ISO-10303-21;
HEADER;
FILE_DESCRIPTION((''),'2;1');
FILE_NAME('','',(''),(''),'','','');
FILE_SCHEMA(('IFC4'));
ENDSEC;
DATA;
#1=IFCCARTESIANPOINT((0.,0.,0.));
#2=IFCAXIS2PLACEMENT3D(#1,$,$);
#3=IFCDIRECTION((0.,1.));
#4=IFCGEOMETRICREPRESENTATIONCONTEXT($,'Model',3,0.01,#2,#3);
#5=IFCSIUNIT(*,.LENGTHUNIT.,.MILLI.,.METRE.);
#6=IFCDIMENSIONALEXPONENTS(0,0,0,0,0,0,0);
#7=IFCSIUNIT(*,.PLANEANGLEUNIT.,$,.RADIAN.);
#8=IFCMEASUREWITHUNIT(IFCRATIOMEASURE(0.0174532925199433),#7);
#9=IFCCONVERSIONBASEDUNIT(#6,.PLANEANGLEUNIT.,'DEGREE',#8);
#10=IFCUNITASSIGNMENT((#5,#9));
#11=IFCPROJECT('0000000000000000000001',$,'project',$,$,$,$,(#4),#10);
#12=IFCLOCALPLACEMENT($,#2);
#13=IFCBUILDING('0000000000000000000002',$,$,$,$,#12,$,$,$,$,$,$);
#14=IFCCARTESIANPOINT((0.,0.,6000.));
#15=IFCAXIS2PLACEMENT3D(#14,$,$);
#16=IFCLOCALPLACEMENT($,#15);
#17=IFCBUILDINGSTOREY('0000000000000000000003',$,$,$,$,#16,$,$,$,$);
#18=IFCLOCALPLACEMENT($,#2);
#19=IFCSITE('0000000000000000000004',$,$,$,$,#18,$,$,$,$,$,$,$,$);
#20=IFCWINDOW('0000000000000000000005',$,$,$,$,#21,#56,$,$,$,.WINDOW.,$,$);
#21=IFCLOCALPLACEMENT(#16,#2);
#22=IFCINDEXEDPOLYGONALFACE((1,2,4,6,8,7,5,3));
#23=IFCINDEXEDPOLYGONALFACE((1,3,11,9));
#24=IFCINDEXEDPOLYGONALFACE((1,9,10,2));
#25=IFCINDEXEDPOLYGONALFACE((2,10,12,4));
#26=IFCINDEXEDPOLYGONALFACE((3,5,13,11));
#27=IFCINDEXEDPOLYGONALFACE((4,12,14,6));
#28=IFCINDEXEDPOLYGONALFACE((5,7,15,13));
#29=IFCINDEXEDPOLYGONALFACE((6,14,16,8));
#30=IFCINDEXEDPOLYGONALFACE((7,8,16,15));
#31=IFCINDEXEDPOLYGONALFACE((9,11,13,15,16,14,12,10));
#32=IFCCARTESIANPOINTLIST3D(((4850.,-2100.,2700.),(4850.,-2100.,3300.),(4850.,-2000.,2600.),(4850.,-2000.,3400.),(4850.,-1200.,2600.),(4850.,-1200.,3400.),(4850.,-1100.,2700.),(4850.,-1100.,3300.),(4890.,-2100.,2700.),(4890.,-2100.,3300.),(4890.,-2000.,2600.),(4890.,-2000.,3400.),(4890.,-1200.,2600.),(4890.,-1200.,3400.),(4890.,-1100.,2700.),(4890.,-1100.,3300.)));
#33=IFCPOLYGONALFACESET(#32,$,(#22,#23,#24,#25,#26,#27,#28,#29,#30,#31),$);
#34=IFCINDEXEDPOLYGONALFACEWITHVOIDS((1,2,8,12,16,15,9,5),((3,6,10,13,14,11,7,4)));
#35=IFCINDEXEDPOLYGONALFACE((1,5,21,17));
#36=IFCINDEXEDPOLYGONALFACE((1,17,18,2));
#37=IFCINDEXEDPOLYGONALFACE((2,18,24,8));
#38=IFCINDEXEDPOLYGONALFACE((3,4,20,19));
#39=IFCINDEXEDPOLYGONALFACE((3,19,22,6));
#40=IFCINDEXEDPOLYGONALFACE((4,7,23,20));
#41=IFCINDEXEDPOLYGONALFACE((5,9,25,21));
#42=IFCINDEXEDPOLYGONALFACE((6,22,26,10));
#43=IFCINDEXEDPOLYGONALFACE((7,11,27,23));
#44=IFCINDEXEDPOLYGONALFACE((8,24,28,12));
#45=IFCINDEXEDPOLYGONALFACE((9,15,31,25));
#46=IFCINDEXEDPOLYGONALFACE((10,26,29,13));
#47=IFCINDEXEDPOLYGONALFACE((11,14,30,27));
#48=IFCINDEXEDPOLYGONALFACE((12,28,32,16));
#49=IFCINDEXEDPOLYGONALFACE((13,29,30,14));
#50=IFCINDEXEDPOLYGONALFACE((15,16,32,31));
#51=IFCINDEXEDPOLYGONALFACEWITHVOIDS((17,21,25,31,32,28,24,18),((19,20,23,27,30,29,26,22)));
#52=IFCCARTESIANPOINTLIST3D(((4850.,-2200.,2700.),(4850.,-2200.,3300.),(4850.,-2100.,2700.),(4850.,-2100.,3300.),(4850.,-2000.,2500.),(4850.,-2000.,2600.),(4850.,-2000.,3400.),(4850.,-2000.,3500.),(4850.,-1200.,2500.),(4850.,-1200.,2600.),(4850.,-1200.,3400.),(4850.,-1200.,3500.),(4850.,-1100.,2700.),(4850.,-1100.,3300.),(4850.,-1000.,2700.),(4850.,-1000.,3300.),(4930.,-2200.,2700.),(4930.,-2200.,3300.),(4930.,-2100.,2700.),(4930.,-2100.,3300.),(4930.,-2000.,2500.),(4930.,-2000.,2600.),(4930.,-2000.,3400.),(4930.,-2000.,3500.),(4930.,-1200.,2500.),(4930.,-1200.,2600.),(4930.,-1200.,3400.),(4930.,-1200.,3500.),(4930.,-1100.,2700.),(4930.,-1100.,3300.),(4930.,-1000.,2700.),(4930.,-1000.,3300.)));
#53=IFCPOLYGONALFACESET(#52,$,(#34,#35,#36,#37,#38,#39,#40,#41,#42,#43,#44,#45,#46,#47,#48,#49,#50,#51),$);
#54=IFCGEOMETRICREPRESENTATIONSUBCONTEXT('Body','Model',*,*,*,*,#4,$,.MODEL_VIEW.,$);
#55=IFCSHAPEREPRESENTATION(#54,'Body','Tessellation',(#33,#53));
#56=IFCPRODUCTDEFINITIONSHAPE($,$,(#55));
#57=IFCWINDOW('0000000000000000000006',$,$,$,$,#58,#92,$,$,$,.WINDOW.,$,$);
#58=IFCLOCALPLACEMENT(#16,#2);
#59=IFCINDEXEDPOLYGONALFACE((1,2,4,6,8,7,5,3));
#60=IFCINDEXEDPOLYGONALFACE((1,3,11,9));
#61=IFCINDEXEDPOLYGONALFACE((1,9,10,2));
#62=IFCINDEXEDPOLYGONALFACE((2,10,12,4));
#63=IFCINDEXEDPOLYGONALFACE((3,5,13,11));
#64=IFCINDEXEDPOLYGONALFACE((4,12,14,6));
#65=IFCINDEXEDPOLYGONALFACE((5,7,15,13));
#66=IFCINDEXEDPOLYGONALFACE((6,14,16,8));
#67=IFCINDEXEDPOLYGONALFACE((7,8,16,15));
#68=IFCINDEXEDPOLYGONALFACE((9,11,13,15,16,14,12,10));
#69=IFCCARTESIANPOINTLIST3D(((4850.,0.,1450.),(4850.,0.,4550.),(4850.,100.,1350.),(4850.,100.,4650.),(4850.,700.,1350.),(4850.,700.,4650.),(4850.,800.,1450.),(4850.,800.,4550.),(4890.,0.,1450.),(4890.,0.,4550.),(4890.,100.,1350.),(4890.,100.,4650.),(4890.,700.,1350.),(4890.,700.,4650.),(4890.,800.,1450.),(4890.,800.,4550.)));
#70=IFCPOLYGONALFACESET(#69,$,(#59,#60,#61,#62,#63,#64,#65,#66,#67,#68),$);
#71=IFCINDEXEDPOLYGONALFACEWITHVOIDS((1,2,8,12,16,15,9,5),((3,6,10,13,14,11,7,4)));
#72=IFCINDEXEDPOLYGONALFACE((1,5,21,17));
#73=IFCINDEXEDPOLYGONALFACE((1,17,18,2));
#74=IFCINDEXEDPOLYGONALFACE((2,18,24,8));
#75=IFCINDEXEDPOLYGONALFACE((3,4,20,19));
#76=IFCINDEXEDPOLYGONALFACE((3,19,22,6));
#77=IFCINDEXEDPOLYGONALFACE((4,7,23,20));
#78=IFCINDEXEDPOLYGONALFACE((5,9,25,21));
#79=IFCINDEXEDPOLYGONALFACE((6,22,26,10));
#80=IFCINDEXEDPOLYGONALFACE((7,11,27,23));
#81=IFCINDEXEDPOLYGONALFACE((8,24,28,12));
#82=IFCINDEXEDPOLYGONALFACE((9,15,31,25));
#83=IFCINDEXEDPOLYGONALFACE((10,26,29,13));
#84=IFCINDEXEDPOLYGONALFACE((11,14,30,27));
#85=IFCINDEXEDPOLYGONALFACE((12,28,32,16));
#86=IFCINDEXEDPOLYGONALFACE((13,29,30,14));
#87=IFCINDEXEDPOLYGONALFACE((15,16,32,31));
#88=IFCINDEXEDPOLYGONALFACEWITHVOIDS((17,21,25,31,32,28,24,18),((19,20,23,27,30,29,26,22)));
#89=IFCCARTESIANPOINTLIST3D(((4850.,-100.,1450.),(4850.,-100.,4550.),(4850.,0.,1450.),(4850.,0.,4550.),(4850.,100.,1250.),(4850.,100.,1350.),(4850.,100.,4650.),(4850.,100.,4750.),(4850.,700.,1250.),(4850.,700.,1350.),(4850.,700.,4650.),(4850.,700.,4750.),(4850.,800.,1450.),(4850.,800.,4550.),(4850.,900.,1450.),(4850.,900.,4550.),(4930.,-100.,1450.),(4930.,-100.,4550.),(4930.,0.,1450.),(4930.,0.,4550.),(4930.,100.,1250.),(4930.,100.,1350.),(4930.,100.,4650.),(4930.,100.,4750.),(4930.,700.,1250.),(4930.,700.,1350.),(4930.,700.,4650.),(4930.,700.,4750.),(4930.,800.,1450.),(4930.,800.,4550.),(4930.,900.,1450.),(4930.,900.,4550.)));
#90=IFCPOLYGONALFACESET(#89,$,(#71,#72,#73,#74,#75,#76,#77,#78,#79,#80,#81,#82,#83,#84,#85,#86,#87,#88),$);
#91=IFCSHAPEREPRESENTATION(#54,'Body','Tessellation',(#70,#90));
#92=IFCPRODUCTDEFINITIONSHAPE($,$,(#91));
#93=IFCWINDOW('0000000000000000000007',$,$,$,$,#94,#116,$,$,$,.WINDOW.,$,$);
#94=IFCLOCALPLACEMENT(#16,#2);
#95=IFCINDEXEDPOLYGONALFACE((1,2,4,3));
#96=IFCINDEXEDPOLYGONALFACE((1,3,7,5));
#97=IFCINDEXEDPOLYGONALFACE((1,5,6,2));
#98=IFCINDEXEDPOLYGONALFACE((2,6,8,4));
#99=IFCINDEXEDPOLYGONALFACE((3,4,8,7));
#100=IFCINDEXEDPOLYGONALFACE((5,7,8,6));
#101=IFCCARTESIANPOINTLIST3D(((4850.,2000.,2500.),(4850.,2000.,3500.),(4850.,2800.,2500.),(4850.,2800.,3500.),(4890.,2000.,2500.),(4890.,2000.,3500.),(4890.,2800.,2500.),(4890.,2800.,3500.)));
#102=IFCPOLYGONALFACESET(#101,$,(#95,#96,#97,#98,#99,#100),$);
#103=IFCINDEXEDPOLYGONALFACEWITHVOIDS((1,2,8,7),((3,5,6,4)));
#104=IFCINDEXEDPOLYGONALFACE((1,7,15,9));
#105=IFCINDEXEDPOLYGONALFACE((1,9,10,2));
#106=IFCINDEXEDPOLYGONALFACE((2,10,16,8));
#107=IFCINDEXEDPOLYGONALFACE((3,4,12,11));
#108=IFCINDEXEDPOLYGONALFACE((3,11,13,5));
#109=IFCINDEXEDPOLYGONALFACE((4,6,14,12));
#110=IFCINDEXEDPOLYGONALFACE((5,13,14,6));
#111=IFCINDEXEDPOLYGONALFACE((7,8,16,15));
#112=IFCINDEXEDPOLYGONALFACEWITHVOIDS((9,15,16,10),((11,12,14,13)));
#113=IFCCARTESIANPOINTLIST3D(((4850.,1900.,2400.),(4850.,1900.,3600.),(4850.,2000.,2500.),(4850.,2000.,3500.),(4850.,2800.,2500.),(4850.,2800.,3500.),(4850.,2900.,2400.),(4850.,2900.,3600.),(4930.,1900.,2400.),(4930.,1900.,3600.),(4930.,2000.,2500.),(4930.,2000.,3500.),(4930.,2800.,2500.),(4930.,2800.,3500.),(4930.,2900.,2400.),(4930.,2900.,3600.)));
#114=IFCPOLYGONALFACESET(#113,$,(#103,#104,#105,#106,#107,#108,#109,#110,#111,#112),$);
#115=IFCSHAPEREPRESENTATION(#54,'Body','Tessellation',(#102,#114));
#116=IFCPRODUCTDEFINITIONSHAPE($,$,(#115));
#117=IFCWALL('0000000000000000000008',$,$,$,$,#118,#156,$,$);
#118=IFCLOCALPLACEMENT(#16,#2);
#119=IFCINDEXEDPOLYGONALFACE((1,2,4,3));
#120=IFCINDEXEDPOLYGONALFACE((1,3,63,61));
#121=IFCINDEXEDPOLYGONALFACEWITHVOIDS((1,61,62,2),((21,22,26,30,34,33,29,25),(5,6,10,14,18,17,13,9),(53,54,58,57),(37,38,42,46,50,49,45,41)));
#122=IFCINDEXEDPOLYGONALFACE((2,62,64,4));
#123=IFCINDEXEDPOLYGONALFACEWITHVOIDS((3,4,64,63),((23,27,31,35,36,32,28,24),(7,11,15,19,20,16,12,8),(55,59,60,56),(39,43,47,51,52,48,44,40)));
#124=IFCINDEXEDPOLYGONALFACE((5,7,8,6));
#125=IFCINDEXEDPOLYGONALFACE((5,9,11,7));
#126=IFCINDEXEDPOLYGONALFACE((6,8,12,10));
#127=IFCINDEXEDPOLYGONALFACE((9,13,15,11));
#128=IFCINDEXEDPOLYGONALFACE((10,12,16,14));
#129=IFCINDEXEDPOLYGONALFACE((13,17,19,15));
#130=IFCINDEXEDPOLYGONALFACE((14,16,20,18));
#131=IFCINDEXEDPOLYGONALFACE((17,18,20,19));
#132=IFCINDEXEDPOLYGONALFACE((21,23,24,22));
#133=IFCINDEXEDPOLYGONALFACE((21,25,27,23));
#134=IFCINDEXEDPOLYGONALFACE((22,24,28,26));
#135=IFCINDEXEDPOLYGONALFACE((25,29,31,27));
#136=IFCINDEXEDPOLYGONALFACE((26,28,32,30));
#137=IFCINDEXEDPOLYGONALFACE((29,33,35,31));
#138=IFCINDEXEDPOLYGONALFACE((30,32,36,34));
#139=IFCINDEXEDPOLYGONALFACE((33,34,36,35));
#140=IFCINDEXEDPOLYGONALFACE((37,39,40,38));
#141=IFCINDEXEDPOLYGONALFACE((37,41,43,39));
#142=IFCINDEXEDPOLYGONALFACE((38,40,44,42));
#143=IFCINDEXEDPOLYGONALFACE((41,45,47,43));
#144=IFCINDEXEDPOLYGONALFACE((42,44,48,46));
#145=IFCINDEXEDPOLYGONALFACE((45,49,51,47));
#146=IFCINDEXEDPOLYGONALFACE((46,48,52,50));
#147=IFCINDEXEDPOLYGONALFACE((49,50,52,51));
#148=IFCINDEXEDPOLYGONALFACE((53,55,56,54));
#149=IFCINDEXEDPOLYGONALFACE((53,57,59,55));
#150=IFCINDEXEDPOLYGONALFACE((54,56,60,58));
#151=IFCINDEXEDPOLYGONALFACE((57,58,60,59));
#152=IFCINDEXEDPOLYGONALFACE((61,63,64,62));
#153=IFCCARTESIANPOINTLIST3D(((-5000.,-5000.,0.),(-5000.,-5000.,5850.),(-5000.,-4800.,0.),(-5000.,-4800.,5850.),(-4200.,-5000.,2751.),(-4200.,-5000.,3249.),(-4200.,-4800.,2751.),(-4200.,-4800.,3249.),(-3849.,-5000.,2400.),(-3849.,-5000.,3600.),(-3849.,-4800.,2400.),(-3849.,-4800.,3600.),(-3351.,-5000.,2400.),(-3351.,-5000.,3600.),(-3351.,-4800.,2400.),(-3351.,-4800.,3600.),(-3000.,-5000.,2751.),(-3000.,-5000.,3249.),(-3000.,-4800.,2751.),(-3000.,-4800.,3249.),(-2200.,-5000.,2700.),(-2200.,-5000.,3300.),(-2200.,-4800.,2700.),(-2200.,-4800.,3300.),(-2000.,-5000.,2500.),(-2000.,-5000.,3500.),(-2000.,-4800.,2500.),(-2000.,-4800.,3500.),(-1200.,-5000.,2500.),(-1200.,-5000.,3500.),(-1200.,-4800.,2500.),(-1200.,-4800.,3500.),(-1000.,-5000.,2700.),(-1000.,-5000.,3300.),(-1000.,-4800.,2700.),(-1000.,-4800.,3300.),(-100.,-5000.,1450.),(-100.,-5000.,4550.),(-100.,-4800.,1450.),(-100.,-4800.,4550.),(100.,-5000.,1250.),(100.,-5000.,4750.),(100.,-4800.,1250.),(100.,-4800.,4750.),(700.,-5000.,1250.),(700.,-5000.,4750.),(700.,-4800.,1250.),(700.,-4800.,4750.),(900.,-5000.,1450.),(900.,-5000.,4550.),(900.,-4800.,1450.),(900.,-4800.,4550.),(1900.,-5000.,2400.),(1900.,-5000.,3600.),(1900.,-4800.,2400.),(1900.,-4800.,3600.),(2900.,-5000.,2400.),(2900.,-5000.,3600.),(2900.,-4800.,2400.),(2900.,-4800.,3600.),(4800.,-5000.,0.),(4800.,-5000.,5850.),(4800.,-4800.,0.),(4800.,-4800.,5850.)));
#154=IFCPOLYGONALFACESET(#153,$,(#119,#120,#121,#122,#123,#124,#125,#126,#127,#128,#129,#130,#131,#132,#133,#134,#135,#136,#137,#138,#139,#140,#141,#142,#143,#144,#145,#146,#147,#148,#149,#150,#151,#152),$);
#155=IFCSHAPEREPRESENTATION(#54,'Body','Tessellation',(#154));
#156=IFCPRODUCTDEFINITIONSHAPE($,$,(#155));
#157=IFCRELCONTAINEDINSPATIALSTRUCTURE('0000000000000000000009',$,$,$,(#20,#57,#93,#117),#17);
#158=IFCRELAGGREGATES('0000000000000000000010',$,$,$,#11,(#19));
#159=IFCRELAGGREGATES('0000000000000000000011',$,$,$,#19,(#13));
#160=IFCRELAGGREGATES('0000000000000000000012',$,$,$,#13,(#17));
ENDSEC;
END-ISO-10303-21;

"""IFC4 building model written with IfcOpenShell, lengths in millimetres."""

from ifc_helpers import new_model, entity, si_unit, converted_unit, direction, frame, origin, origin_2d, place, context, subcontext, project, spatial, polyline, rectangle, outline, extrude, element, save


model = new_model("IFC4")

# Units and contexts
model_context = context("Model", 3, precision=0.01, world=origin(), true_north=direction((0.0, 1.0)))
body_context = subcontext(model_context, "Body", "Model", "MODEL_VIEW")
ifc_project = project(units=[si_unit("LENGTHUNIT", "METRE", prefix="MILLI"), converted_unit("PLANEANGLEUNIT", "DEGREE", entity("IfcRatioMeasure", 0.0174532925199433), si_unit("PLANEANGLEUNIT", "RADIAN"), dimensions=[0, 0, 0, 0, 0, 0, 0])], contexts=[model_context])

# Site, building, storey
site_placement = place(None, origin())
site = spatial("IfcSite", under=ifc_project, at=site_placement)
building_placement = place(None, origin())
building = spatial("IfcBuilding", under=site, at=building_placement)
storey_placement = place(None, frame((0.0, 0.0, 6000.0)))
storey = spatial("IfcBuildingStorey", under=building, at=storey_placement)

# Shared definitions
cartesian_point_1 = entity("IfcCartesianPoint", [-500.0, -300.0])
shared_polyline_1 = entity("IfcPolyline", [cartesian_point_1, entity("IfcCartesianPoint", [-500.0, 300.0]), entity("IfcCartesianPoint", [-400.0, 400.0]), entity("IfcCartesianPoint", [400.0, 400.0]), entity("IfcCartesianPoint", [500.0, 300.0]), entity("IfcCartesianPoint", [500.0, -300.0]), entity("IfcCartesianPoint", [400.0, -400.0]), entity("IfcCartesianPoint", [-400.0, -400.0]), cartesian_point_1])
cartesian_point_2 = entity("IfcCartesianPoint", [-400.0, -1550.0])
shared_polyline_2 = entity("IfcPolyline", [cartesian_point_2, entity("IfcCartesianPoint", [-400.0, 1550.0]), entity("IfcCartesianPoint", [-300.0, 1650.0]), entity("IfcCartesianPoint", [300.0, 1650.0]), entity("IfcCartesianPoint", [400.0, 1550.0]), entity("IfcCartesianPoint", [400.0, -1550.0]), entity("IfcCartesianPoint", [300.0, -1650.0]), entity("IfcCartesianPoint", [-300.0, -1650.0]), cartesian_point_2])
cartesian_point_3 = entity("IfcCartesianPoint", [-400.0, -500.0])
shared_polyline_3 = entity("IfcPolyline", [cartesian_point_3, entity("IfcCartesianPoint", [-400.0, 500.0]), entity("IfcCartesianPoint", [-400.0, 500.0]), entity("IfcCartesianPoint", [400.0, 500.0]), entity("IfcCartesianPoint", [400.0, 500.0]), entity("IfcCartesianPoint", [400.0, -500.0]), entity("IfcCartesianPoint", [400.0, -500.0]), entity("IfcCartesianPoint", [-400.0, -500.0]), cartesian_point_3])

# Shared definitions
wall_1_placement = place(storey_placement, frame((4900.0, -100.0, 0.0), z_axis=(0.0, 0.0, 1.0), x_axis=(0.0, 1.0, 0.0)))
window_1_placement = place(wall_1_placement, frame((-1500.0, 50.0, 3000.0)))
window_2_placement = place(wall_1_placement, frame((500.0, 50.0, 3000.0)))
window_3_placement = place(wall_1_placement, frame((2500.0, 50.0, 3000.0)))

# Windows
cartesian_point_4 = entity("IfcCartesianPoint", [-600.0, -300.0])
element("IfcWindow", 1, at=window_1_placement, inside=storey, PredefinedType="WINDOW", context=body_context, shape_type="SweptSolid", body=[
    entity("IfcExtrudedAreaSolid", entity("IfcArbitraryClosedProfileDef", "AREA", None, shared_polyline_1), entity("IfcAxis2Placement3D", entity("IfcCartesianPoint", [0.0, 0.0, 0.0]), entity("IfcDirection", [0.0, -1.0, 0.0]), entity("IfcDirection", [1.0, 0.0, 0.0])), entity("IfcDirection", [0.0, 0.0, 1.0]), 40.0),
    entity("IfcExtrudedAreaSolid", entity("IfcArbitraryProfileDefWithVoids", "AREA", None, entity("IfcPolyline", [cartesian_point_4, entity("IfcCartesianPoint", [-600.0, 300.0]), entity("IfcCartesianPoint", [-400.0, 500.0]), entity("IfcCartesianPoint", [400.0, 500.0]), entity("IfcCartesianPoint", [600.0, 300.0]), entity("IfcCartesianPoint", [600.0, -300.0]), entity("IfcCartesianPoint", [400.0, -500.0]), entity("IfcCartesianPoint", [-400.0, -500.0]), cartesian_point_4]), [shared_polyline_1]), entity("IfcAxis2Placement3D", entity("IfcCartesianPoint", [0.0, 0.0, 0.0]), entity("IfcDirection", [0.0, -1.0, 0.0]), entity("IfcDirection", [1.0, 0.0, 0.0])), entity("IfcDirection", [0.0, 0.0, 1.0]), 80.0),
])
cartesian_point_5 = entity("IfcCartesianPoint", [-500.0, -1550.0])
element("IfcWindow", 2, at=window_2_placement, inside=storey, PredefinedType="WINDOW", context=body_context, shape_type="SweptSolid", body=[
    entity("IfcExtrudedAreaSolid", entity("IfcArbitraryClosedProfileDef", "AREA", None, shared_polyline_2), entity("IfcAxis2Placement3D", entity("IfcCartesianPoint", [0.0, 0.0, 0.0]), entity("IfcDirection", [0.0, -1.0, 0.0]), entity("IfcDirection", [1.0, 0.0, 0.0])), entity("IfcDirection", [0.0, 0.0, 1.0]), 40.0),
    entity("IfcExtrudedAreaSolid", entity("IfcArbitraryProfileDefWithVoids", "AREA", None, entity("IfcPolyline", [cartesian_point_5, entity("IfcCartesianPoint", [-500.0, 1550.0]), entity("IfcCartesianPoint", [-300.0, 1750.0]), entity("IfcCartesianPoint", [300.0, 1750.0]), entity("IfcCartesianPoint", [500.0, 1550.0]), entity("IfcCartesianPoint", [500.0, -1550.0]), entity("IfcCartesianPoint", [300.0, -1750.0]), entity("IfcCartesianPoint", [-300.0, -1750.0]), cartesian_point_5]), [shared_polyline_2]), entity("IfcAxis2Placement3D", entity("IfcCartesianPoint", [0.0, 0.0, 0.0]), entity("IfcDirection", [0.0, -1.0, 0.0]), entity("IfcDirection", [1.0, 0.0, 0.0])), entity("IfcDirection", [0.0, 0.0, 1.0]), 80.0),
])
cartesian_point_6 = entity("IfcCartesianPoint", [-500.0, -600.0])
element("IfcWindow", 3, at=window_3_placement, inside=storey, PredefinedType="WINDOW", context=body_context, shape_type="SweptSolid", body=[
    entity("IfcExtrudedAreaSolid", entity("IfcArbitraryClosedProfileDef", "AREA", None, shared_polyline_3), entity("IfcAxis2Placement3D", entity("IfcCartesianPoint", [0.0, 0.0, 0.0]), entity("IfcDirection", [0.0, -1.0, 0.0]), entity("IfcDirection", [1.0, 0.0, 0.0])), entity("IfcDirection", [0.0, 0.0, 1.0]), 40.0),
    entity("IfcExtrudedAreaSolid", entity("IfcArbitraryProfileDefWithVoids", "AREA", None, entity("IfcPolyline", [cartesian_point_6, entity("IfcCartesianPoint", [-500.0, 600.0]), entity("IfcCartesianPoint", [-500.0, 600.0]), entity("IfcCartesianPoint", [500.0, 600.0]), entity("IfcCartesianPoint", [500.0, 600.0]), entity("IfcCartesianPoint", [500.0, -600.0]), entity("IfcCartesianPoint", [500.0, -600.0]), entity("IfcCartesianPoint", [-500.0, -600.0]), cartesian_point_6]), [shared_polyline_3]), entity("IfcAxis2Placement3D", entity("IfcCartesianPoint", [0.0, 0.0, 0.0]), entity("IfcDirection", [0.0, -1.0, 0.0]), entity("IfcDirection", [1.0, 0.0, 0.0])), entity("IfcDirection", [0.0, 0.0, 1.0]), 80.0),
])

# Wall, openings
wall_2_placement = place(storey_placement, frame((-100.0, -4900.0, 0.0), z_axis=(0.0, 0.0, 1.0), x_axis=(1.0, 0.0, 0.0)))
wall_2 = element("IfcWall", 4, at=wall_2_placement, inside=storey, context=body_context, shape_type="SweptSolid", body=[
    extrude(rectangle(XDim=9800.0, YDim=200.0, at=origin_2d()), origin(), (0.0, 0.0, 1.0), 5850.0),
])
window_4_placement = place(wall_2_placement, frame((-3500.0, 50.0, 3000.0)))
opening_1_placement = place(window_4_placement, frame((0.0, 50.0, 0.0)))
element("IfcOpeningElement", 5, at=opening_1_placement, cuts=wall_2, context=body_context, shape_type="SweptSolid", body=[
    extrude(outline(polyline([(-600.0, -249.0), (-600.0, 249.0), (-249.0, 600.0), (249.0, 600.0), (600.0, 249.0), (600.0, -249.0), (249.0, -600.0), (-249.0, -600.0), (-600.0, -249.0)])), frame((0.0, 0.0, 0.0), z_axis=(0.0, -1.0, 0.0), x_axis=(1.0, 0.0, 0.0)), (0.0, 0.0, 1.0), 200.0),
])
window_5_placement = place(wall_2_placement, frame((-1500.0, 50.0, 3000.0)))
opening_2_placement = place(window_5_placement, frame((0.0, 50.0, 0.0)))
element("IfcOpeningElement", 6, at=opening_2_placement, cuts=wall_2, context=body_context, shape_type="SweptSolid", body=[
    extrude(outline(polyline([(-600.0, -300.0), (-600.0, 300.0), (-400.0, 500.0), (400.0, 500.0), (600.0, 300.0), (600.0, -300.0), (400.0, -500.0), (-400.0, -500.0), (-600.0, -300.0)])), frame((0.0, 0.0, 0.0), z_axis=(0.0, -1.0, 0.0), x_axis=(1.0, 0.0, 0.0)), (0.0, 0.0, 1.0), 200.0),
])
window_6_placement = place(wall_2_placement, frame((500.0, 50.0, 3000.0)))
opening_3_placement = place(window_6_placement, frame((0.0, 50.0, 0.0)))
element("IfcOpeningElement", 7, at=opening_3_placement, cuts=wall_2, context=body_context, shape_type="SweptSolid", body=[
    extrude(outline(polyline([(-500.0, -1550.0), (-500.0, 1550.0), (-300.0, 1750.0), (300.0, 1750.0), (500.0, 1550.0), (500.0, -1550.0), (300.0, -1750.0), (-300.0, -1750.0), (-500.0, -1550.0)])), frame((0.0, 0.0, 0.0), z_axis=(0.0, -1.0, 0.0), x_axis=(1.0, 0.0, 0.0)), (0.0, 0.0, 1.0), 200.0),
])
window_7_placement = place(wall_2_placement, frame((2500.0, 50.0, 3000.0)))
opening_4_placement = place(window_7_placement, frame((0.0, 50.0, 0.0)))
element("IfcOpeningElement", 8, at=opening_4_placement, cuts=wall_2, context=body_context, shape_type="SweptSolid", body=[
    extrude(outline(polyline([(-500.0, -600.0), (-500.0, 600.0), (-500.0, 600.0), (500.0, 600.0), (500.0, 600.0), (500.0, -600.0), (500.0, -600.0), (-500.0, -600.0), (-500.0, -600.0)])), frame((0.0, 0.0, 0.0), z_axis=(0.0, -1.0, 0.0), x_axis=(1.0, 0.0, 0.0)), (0.0, 0.0, 1.0), 200.0),
])

save(model, "model.ifc")
